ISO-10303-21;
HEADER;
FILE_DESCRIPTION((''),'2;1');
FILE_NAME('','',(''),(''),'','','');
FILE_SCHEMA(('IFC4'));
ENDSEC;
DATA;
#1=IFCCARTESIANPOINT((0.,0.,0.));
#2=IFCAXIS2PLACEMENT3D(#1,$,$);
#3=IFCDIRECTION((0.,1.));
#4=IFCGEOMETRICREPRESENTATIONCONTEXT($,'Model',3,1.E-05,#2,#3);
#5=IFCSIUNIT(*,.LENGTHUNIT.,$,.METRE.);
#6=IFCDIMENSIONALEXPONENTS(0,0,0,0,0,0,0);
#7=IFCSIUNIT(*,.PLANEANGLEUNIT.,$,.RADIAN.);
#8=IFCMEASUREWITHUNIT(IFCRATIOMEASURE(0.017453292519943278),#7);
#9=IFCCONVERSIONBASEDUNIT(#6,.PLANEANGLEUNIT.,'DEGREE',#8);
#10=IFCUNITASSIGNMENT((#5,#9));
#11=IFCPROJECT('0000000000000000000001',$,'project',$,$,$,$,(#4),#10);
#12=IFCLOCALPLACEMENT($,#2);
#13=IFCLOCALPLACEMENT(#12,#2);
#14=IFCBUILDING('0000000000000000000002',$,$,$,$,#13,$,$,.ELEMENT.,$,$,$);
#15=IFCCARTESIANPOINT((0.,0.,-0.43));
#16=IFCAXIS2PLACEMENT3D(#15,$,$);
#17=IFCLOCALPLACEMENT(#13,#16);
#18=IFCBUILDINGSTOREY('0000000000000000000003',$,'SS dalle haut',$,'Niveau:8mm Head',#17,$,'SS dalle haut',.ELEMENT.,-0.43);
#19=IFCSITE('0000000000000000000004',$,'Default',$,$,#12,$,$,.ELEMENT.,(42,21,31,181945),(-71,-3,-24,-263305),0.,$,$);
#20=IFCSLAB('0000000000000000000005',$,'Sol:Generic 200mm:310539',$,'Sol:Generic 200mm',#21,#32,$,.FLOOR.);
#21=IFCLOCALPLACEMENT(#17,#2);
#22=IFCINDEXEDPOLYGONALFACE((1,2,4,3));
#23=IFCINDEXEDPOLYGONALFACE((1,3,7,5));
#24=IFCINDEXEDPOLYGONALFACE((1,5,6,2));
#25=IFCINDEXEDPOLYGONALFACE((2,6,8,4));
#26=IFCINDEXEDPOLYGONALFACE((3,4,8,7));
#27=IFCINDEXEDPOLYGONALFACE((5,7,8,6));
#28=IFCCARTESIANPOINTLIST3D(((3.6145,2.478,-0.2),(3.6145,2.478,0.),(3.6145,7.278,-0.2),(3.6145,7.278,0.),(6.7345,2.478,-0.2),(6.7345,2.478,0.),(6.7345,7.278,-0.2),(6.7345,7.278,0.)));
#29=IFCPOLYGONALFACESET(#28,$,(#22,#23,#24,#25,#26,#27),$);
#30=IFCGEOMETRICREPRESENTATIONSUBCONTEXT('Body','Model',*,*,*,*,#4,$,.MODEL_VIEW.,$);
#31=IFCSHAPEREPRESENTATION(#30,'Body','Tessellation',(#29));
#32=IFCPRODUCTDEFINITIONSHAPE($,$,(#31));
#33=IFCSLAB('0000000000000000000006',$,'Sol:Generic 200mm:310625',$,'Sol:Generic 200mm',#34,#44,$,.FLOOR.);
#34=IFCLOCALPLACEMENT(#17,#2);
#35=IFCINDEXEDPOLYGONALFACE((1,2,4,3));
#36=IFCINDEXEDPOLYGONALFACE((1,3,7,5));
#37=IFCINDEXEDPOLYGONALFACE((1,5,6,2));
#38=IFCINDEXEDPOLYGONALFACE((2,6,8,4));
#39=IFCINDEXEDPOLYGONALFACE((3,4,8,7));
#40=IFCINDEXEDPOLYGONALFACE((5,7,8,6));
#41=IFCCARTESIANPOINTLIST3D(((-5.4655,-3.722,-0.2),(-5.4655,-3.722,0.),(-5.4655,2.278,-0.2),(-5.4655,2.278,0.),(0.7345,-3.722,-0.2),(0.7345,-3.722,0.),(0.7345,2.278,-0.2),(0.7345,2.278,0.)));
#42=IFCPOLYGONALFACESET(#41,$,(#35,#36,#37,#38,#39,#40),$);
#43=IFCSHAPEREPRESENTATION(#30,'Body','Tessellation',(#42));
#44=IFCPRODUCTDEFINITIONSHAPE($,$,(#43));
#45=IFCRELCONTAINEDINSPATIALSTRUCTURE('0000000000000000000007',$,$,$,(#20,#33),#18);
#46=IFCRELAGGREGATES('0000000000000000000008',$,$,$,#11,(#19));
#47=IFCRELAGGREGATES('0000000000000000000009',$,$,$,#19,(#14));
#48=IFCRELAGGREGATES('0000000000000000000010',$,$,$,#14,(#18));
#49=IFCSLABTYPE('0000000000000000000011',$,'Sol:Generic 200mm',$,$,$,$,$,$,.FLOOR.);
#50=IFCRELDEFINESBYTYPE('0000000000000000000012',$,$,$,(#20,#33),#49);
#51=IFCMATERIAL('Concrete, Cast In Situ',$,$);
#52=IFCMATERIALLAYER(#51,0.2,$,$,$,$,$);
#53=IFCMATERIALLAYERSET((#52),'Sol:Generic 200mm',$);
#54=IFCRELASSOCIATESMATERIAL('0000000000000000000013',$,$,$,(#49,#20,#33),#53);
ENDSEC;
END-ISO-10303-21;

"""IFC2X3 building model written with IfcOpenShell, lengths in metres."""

from ifc_helpers import new_model, entity, si_unit, converted_unit, direction, frame, frame_2d, origin, place, context, subcontext, project, spatial, rectangle, extrude, material, layer, layer_set, layer_usage, type_object, element, save


model = new_model("IFC2X3")

# Units and contexts
model_context = context("Model", 3, precision=1e-05, world=origin(), true_north=direction((0.0, 1.0)))
body_context = subcontext(model_context, "Body", "Model", "MODEL_VIEW")
ifc_project = project(units=[si_unit("LENGTHUNIT", "METRE"), converted_unit("PLANEANGLEUNIT", "DEGREE", entity("IfcRatioMeasure", 0.017453292519943278), si_unit("PLANEANGLEUNIT", "RADIAN"), dimensions=[0, 0, 0, 0, 0, 0, 0])], contexts=[model_context])

# Site, building, storey
site_placement = place(None, origin())
site = spatial("IfcSite", under=ifc_project, at=site_placement, Name="Default", CompositionType="ELEMENT", RefLatitude=(42, 21, 31, 181945), RefLongitude=(-71, -3, -24, -263305), RefElevation=0.0)
building_placement = place(site_placement, origin())
building = spatial("IfcBuilding", under=site, at=building_placement, CompositionType="ELEMENT")
storey_placement = place(building_placement, frame((0.0, 0.0, -0.43)))
storey = spatial("IfcBuildingStorey", under=building, at=storey_placement, Name="SS dalle haut", ObjectType="Niveau:8mm Head", LongName="SS dalle haut", CompositionType="ELEMENT", Elevation=-0.43)

# Slabs
ifc_material_1 = material(Name="Concrete, Cast In Situ")
ifc_layer = layer(ifc_material_1, 0.2)
ifc_layer_set = layer_set([ifc_layer], Name="Sol:Generic 200mm")
ifc_layer_usage = layer_usage(ifc_layer_set, "AXIS3", "POSITIVE", 0.0)
slab_type = type_object("IfcSlabType", Name="Sol:Generic 200mm", PredefinedType="FLOOR", material=ifc_layer_set)
slab_1_placement = place(storey_placement, origin())
element("IfcSlab", 1, at=slab_1_placement, inside=storey, type_object=slab_type, material=ifc_layer_usage, Name="Sol:Generic 200mm:310539", ObjectType="Sol:Generic 200mm", PredefinedType="FLOOR", context=body_context, shape_type="SweptSolid", body=[
    extrude(rectangle(XDim=4.8, YDim=3.12, at=frame_2d((0.0, 0.0), x_axis=(1.0, 0.0))), frame((5.1745, 4.878, 0.0), z_axis=(0.0, 0.0, -1.0), x_axis=(0.0, 1.0, 0.0)), (0.0, 0.0, 1.0), 0.2),
])
slab_2_placement = place(storey_placement, origin())
element("IfcSlab", 2, at=slab_2_placement, inside=storey, type_object=slab_type, material=ifc_layer_usage, Name="Sol:Generic 200mm:310625", ObjectType="Sol:Generic 200mm", PredefinedType="FLOOR", context=body_context, shape_type="SweptSolid", body=[
    extrude(rectangle(XDim=6.0, YDim=6.2, at=frame_2d((0.0, 0.0), x_axis=(1.0, 0.0))), frame((-2.3655, -0.722, 0.0), z_axis=(0.0, 0.0, -1.0), x_axis=(0.0, 1.0, 0.0)), (0.0, 0.0, 1.0), 0.2),
])

save(model, "model.ifc")
